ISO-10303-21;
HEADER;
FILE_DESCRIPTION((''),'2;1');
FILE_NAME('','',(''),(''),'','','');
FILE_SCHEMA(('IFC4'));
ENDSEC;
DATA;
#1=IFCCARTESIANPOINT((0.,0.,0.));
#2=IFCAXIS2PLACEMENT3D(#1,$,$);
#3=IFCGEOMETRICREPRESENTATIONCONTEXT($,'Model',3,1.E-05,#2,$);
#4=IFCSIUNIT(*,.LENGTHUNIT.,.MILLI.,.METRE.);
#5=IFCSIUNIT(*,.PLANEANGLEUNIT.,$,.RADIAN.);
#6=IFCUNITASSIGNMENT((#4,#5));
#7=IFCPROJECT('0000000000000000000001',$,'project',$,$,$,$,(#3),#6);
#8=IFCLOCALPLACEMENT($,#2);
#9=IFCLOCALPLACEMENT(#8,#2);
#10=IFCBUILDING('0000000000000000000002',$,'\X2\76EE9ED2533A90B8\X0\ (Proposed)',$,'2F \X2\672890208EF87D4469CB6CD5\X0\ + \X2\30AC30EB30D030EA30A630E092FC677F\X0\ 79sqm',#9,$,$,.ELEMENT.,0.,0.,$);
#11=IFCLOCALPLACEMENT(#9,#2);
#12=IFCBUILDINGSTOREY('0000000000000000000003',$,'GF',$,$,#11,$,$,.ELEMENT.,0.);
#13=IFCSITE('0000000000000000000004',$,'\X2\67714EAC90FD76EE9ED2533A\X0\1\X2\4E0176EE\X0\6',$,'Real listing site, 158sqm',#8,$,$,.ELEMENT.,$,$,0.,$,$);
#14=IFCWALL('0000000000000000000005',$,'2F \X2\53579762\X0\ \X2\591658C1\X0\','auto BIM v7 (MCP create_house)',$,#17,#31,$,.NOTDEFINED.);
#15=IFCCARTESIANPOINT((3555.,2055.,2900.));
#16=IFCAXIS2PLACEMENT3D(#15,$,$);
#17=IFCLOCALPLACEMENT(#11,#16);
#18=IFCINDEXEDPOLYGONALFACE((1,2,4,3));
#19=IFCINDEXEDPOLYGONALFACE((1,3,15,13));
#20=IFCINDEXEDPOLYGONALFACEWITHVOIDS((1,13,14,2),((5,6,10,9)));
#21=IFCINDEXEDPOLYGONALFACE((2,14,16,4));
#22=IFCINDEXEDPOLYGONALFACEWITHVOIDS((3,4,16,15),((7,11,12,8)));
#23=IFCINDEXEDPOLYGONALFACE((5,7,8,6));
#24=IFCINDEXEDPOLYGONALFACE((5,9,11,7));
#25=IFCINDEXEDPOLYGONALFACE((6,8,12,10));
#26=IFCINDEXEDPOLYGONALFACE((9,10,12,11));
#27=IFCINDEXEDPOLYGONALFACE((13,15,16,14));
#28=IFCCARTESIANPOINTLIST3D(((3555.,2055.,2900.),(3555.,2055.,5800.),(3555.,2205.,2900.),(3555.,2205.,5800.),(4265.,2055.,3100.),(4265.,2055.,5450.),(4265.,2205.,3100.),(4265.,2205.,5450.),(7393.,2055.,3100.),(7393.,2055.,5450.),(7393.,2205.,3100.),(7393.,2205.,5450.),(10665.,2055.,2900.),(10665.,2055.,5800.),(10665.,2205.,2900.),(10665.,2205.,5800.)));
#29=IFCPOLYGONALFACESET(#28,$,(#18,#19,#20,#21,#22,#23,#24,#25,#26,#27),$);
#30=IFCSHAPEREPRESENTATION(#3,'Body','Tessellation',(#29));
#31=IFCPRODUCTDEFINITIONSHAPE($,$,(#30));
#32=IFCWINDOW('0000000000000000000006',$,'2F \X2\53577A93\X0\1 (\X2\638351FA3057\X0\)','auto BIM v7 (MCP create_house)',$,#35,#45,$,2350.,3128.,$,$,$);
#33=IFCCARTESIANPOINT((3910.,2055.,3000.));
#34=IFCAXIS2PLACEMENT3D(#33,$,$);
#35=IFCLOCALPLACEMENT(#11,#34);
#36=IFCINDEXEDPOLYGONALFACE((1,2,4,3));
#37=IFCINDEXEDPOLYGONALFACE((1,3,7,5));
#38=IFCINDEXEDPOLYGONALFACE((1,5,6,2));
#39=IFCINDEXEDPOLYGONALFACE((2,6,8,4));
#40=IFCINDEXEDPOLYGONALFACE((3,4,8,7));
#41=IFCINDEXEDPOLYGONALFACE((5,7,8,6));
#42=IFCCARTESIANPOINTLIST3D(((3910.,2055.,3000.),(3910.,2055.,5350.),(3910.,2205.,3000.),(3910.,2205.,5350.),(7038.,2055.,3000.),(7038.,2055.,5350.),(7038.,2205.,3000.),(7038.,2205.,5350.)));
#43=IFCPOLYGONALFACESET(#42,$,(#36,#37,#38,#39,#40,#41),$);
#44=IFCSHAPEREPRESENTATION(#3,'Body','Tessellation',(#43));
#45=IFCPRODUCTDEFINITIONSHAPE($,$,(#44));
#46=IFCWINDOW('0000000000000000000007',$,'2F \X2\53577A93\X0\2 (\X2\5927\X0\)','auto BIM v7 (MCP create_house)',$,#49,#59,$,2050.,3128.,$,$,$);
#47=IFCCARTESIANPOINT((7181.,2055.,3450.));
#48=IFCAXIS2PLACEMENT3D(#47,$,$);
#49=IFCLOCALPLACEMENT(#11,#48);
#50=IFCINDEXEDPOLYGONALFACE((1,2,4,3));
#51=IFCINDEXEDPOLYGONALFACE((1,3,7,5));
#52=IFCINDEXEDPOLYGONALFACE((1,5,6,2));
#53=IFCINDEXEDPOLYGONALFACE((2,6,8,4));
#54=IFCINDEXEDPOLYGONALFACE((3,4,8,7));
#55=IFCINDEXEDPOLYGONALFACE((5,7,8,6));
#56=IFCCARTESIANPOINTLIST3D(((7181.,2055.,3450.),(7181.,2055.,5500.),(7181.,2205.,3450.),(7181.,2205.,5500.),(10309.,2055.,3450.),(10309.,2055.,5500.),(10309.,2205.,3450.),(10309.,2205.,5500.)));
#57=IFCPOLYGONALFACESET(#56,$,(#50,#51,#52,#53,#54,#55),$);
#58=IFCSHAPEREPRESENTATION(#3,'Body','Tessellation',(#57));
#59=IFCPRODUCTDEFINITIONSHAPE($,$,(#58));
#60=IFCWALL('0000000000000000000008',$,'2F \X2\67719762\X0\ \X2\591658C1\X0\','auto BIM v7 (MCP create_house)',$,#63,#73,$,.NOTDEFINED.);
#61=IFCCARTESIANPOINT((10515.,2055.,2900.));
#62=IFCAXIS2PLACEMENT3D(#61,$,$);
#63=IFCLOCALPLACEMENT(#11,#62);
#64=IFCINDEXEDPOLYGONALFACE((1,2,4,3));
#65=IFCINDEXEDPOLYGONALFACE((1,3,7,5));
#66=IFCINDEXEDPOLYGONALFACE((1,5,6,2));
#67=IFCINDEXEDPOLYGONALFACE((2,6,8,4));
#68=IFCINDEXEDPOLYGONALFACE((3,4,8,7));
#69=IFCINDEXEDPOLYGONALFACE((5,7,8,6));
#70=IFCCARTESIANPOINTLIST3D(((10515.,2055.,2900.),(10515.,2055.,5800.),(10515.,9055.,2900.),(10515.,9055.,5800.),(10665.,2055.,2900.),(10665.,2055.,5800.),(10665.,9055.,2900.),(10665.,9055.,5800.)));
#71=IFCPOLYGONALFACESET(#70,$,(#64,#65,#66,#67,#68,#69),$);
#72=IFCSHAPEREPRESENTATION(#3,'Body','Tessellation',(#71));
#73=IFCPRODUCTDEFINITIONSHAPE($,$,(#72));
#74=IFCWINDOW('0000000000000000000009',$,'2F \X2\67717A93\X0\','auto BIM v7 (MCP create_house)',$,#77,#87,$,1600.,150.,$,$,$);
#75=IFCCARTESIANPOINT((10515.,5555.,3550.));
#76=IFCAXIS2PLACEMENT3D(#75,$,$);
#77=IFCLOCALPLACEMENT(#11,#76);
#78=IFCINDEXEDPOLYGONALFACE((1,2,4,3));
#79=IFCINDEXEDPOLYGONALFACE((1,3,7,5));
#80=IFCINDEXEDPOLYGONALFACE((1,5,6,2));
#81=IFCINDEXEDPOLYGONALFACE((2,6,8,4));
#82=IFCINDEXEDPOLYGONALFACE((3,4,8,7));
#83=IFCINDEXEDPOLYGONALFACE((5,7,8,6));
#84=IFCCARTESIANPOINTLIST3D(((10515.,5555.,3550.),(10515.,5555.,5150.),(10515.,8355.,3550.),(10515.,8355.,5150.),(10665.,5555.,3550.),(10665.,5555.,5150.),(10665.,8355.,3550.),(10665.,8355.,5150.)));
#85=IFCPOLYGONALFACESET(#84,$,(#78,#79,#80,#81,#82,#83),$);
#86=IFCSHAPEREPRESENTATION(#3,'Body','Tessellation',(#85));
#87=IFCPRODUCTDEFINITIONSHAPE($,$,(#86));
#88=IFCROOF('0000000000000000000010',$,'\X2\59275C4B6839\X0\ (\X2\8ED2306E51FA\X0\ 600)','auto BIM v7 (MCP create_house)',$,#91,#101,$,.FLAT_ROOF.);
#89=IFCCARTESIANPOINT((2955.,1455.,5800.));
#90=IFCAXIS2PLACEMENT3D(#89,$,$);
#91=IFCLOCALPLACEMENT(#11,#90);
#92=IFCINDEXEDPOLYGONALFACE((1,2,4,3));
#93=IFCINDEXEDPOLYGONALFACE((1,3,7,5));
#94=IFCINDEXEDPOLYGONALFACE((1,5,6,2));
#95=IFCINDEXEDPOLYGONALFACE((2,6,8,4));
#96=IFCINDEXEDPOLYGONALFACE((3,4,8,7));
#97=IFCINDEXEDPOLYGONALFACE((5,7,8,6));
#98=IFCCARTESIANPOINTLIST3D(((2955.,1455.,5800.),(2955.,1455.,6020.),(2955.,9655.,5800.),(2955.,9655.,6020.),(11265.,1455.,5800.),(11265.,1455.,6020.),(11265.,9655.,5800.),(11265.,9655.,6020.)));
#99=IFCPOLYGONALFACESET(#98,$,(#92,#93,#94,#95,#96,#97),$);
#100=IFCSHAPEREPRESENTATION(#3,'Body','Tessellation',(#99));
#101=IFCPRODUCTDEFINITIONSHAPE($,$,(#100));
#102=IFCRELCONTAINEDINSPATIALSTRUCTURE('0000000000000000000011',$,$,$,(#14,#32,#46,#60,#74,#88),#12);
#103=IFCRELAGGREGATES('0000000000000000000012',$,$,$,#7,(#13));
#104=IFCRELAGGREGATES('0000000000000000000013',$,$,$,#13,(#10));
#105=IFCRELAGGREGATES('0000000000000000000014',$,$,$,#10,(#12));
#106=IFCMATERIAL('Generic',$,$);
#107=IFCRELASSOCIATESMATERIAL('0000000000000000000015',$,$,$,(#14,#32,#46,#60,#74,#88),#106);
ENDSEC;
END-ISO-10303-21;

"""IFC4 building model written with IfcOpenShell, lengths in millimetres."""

from ifc_helpers import new_model, si_unit, frame, frame_2d, origin, place, context, project, spatial, rectangle, extrude, material, element, fill, save


model = new_model("IFC4")

# Units and contexts
model_context = context("Model", 3, precision=1e-05, world=origin())
ifc_project = project(units=[si_unit("LENGTHUNIT", "METRE", prefix="MILLI"), si_unit("PLANEANGLEUNIT", "RADIAN")], contexts=[model_context])

# Site, building, storey
site_placement = place(None, origin())
site = spatial("IfcSite", under=ifc_project, at=site_placement, Name="東京都目黒区1丁目6", ObjectType="Real listing site, 158sqm", CompositionType="ELEMENT", RefElevation=0.0)
building_placement = place(site_placement, origin())
building = spatial("IfcBuilding", under=site, at=building_placement, Name="目黒区邸 (Proposed)", ObjectType="2F 木造軸組構法 + ガルバリウム鋼板 79sqm", CompositionType="ELEMENT", ElevationOfRefHeight=0.0, ElevationOfTerrain=0.0)
storey_placement = place(building_placement, origin())
storey = spatial("IfcBuildingStorey", under=building, at=storey_placement, Name="GF", CompositionType="ELEMENT", Elevation=0.0)

# Shared definitions
ifc_material = material(Name="Generic")

# Wall, openings, windows
wall_1_placement = place(storey_placement, frame((3555.0, 2055.0, 2900.0)))
wall_1 = element("IfcWall", 1, at=wall_1_placement, inside=storey, material=ifc_material, Name="2F 南面 外壁", Description="auto BIM v7 (MCP create_house)", PredefinedType="NOTDEFINED", context=model_context, shape_type="SweptSolid", body=[
    extrude(rectangle(XDim=7110.0, YDim=150.0, at=frame_2d((3555.0, 75.0))), frame((3555.0, 2055.0, 2900.0)), (0.0, 0.0, 1.0), 2900.0),
])
opening_1_placement = place(storey_placement, frame((3910.0, 2055.0, 3000.0)))
opening_1 = element("IfcOpeningElement", 2, at=opening_1_placement, cuts=wall_1, PredefinedType="NOTDEFINED", context=model_context, shape_type="SweptSolid", body=[
    extrude(rectangle(XDim=3128.0, YDim=150.0, at=frame_2d((1564.0, 75.0))), frame((3910.0, 2055.0, 3000.0)), (0.0, 0.0, 1.0), 2350.0),
])
opening_2_placement = place(storey_placement, frame((7181.0, 2055.0, 3450.0)))
opening_2 = element("IfcOpeningElement", 3, at=opening_2_placement, cuts=wall_1, PredefinedType="NOTDEFINED", context=model_context, shape_type="SweptSolid", body=[
    extrude(rectangle(XDim=3128.0, YDim=150.0, at=frame_2d((1564.0, 75.0))), frame((7181.0, 2055.0, 3450.0)), (0.0, 0.0, 1.0), 2050.0),
])
window_1_placement = place(storey_placement, frame((3910.0, 2055.0, 3000.0)))
window_1 = element("IfcWindow", 4, at=window_1_placement, inside=storey, material=ifc_material, Name="2F 南窓1 (掃出し)", Description="auto BIM v7 (MCP create_house)", OverallHeight=2350.0, OverallWidth=3128.0, context=model_context, shape_type="SweptSolid", body=[
    extrude(rectangle(XDim=3128.0, YDim=150.0, at=frame_2d((1564.0, 75.0))), frame((3910.0, 2055.0, 3000.0)), (0.0, 0.0, 1.0), 2350.0),
])
fill(opening_1, window_1)
window_2_placement = place(storey_placement, frame((7181.0, 2055.0, 3450.0)))
window_2 = element("IfcWindow", 5, at=window_2_placement, inside=storey, material=ifc_material, Name="2F 南窓2 (大)", Description="auto BIM v7 (MCP create_house)", OverallHeight=2050.0, OverallWidth=3128.0, context=model_context, shape_type="SweptSolid", body=[
    extrude(rectangle(XDim=3128.0, YDim=150.0, at=frame_2d((1564.0, 75.0))), frame((7181.0, 2055.0, 3450.0)), (0.0, 0.0, 1.0), 2050.0),
])
fill(opening_2, window_2)

# Wall, opening, window
wall_2_placement = place(storey_placement, frame((10515.0, 2055.0, 2900.0)))
wall_2 = element("IfcWall", 6, at=wall_2_placement, inside=storey, material=ifc_material, Name="2F 東面 外壁", Description="auto BIM v7 (MCP create_house)", PredefinedType="NOTDEFINED", context=model_context, shape_type="SweptSolid", body=[
    extrude(rectangle(XDim=150.0, YDim=7000.0, at=frame_2d((75.0, 3500.0))), frame((10515.0, 2055.0, 2900.0)), (0.0, 0.0, 1.0), 2900.0),
])
opening_3_placement = place(storey_placement, frame((10515.0, 5555.0, 3550.0)))
opening_3 = element("IfcOpeningElement", 7, at=opening_3_placement, cuts=wall_2, PredefinedType="NOTDEFINED", context=model_context, shape_type="SweptSolid", body=[
    extrude(rectangle(XDim=150.0, YDim=2800.0, at=frame_2d((75.0, 1400.0))), frame((10515.0, 5555.0, 3550.0)), (0.0, 0.0, 1.0), 1600.0),
])
window_3_placement = place(storey_placement, frame((10515.0, 5555.0, 3550.0)))
window_3 = element("IfcWindow", 8, at=window_3_placement, inside=storey, material=ifc_material, Name="2F 東窓", Description="auto BIM v7 (MCP create_house)", OverallHeight=1600.0, OverallWidth=150.0, context=model_context, shape_type="SweptSolid", body=[
    extrude(rectangle(XDim=150.0, YDim=2800.0, at=frame_2d((75.0, 1400.0))), frame((10515.0, 5555.0, 3550.0)), (0.0, 0.0, 1.0), 1600.0),
])
fill(opening_3, window_3)

# Roof
roof_placement = place(storey_placement, frame((2955.0, 1455.0, 5800.0)))
element("IfcRoof", 9, at=roof_placement, inside=storey, material=ifc_material, Name="大屋根 (軒の出 600)", Description="auto BIM v7 (MCP create_house)", PredefinedType="FLAT_ROOF", context=model_context, shape_type="SweptSolid", body=[
    extrude(rectangle(XDim=8310.0, YDim=8200.0, at=frame_2d((4155.0, 4100.0))), frame((2955.0, 1455.0, 5800.0)), (0.0, 0.0, 1.0), 220.0),
])

save(model, "model.ifc")
